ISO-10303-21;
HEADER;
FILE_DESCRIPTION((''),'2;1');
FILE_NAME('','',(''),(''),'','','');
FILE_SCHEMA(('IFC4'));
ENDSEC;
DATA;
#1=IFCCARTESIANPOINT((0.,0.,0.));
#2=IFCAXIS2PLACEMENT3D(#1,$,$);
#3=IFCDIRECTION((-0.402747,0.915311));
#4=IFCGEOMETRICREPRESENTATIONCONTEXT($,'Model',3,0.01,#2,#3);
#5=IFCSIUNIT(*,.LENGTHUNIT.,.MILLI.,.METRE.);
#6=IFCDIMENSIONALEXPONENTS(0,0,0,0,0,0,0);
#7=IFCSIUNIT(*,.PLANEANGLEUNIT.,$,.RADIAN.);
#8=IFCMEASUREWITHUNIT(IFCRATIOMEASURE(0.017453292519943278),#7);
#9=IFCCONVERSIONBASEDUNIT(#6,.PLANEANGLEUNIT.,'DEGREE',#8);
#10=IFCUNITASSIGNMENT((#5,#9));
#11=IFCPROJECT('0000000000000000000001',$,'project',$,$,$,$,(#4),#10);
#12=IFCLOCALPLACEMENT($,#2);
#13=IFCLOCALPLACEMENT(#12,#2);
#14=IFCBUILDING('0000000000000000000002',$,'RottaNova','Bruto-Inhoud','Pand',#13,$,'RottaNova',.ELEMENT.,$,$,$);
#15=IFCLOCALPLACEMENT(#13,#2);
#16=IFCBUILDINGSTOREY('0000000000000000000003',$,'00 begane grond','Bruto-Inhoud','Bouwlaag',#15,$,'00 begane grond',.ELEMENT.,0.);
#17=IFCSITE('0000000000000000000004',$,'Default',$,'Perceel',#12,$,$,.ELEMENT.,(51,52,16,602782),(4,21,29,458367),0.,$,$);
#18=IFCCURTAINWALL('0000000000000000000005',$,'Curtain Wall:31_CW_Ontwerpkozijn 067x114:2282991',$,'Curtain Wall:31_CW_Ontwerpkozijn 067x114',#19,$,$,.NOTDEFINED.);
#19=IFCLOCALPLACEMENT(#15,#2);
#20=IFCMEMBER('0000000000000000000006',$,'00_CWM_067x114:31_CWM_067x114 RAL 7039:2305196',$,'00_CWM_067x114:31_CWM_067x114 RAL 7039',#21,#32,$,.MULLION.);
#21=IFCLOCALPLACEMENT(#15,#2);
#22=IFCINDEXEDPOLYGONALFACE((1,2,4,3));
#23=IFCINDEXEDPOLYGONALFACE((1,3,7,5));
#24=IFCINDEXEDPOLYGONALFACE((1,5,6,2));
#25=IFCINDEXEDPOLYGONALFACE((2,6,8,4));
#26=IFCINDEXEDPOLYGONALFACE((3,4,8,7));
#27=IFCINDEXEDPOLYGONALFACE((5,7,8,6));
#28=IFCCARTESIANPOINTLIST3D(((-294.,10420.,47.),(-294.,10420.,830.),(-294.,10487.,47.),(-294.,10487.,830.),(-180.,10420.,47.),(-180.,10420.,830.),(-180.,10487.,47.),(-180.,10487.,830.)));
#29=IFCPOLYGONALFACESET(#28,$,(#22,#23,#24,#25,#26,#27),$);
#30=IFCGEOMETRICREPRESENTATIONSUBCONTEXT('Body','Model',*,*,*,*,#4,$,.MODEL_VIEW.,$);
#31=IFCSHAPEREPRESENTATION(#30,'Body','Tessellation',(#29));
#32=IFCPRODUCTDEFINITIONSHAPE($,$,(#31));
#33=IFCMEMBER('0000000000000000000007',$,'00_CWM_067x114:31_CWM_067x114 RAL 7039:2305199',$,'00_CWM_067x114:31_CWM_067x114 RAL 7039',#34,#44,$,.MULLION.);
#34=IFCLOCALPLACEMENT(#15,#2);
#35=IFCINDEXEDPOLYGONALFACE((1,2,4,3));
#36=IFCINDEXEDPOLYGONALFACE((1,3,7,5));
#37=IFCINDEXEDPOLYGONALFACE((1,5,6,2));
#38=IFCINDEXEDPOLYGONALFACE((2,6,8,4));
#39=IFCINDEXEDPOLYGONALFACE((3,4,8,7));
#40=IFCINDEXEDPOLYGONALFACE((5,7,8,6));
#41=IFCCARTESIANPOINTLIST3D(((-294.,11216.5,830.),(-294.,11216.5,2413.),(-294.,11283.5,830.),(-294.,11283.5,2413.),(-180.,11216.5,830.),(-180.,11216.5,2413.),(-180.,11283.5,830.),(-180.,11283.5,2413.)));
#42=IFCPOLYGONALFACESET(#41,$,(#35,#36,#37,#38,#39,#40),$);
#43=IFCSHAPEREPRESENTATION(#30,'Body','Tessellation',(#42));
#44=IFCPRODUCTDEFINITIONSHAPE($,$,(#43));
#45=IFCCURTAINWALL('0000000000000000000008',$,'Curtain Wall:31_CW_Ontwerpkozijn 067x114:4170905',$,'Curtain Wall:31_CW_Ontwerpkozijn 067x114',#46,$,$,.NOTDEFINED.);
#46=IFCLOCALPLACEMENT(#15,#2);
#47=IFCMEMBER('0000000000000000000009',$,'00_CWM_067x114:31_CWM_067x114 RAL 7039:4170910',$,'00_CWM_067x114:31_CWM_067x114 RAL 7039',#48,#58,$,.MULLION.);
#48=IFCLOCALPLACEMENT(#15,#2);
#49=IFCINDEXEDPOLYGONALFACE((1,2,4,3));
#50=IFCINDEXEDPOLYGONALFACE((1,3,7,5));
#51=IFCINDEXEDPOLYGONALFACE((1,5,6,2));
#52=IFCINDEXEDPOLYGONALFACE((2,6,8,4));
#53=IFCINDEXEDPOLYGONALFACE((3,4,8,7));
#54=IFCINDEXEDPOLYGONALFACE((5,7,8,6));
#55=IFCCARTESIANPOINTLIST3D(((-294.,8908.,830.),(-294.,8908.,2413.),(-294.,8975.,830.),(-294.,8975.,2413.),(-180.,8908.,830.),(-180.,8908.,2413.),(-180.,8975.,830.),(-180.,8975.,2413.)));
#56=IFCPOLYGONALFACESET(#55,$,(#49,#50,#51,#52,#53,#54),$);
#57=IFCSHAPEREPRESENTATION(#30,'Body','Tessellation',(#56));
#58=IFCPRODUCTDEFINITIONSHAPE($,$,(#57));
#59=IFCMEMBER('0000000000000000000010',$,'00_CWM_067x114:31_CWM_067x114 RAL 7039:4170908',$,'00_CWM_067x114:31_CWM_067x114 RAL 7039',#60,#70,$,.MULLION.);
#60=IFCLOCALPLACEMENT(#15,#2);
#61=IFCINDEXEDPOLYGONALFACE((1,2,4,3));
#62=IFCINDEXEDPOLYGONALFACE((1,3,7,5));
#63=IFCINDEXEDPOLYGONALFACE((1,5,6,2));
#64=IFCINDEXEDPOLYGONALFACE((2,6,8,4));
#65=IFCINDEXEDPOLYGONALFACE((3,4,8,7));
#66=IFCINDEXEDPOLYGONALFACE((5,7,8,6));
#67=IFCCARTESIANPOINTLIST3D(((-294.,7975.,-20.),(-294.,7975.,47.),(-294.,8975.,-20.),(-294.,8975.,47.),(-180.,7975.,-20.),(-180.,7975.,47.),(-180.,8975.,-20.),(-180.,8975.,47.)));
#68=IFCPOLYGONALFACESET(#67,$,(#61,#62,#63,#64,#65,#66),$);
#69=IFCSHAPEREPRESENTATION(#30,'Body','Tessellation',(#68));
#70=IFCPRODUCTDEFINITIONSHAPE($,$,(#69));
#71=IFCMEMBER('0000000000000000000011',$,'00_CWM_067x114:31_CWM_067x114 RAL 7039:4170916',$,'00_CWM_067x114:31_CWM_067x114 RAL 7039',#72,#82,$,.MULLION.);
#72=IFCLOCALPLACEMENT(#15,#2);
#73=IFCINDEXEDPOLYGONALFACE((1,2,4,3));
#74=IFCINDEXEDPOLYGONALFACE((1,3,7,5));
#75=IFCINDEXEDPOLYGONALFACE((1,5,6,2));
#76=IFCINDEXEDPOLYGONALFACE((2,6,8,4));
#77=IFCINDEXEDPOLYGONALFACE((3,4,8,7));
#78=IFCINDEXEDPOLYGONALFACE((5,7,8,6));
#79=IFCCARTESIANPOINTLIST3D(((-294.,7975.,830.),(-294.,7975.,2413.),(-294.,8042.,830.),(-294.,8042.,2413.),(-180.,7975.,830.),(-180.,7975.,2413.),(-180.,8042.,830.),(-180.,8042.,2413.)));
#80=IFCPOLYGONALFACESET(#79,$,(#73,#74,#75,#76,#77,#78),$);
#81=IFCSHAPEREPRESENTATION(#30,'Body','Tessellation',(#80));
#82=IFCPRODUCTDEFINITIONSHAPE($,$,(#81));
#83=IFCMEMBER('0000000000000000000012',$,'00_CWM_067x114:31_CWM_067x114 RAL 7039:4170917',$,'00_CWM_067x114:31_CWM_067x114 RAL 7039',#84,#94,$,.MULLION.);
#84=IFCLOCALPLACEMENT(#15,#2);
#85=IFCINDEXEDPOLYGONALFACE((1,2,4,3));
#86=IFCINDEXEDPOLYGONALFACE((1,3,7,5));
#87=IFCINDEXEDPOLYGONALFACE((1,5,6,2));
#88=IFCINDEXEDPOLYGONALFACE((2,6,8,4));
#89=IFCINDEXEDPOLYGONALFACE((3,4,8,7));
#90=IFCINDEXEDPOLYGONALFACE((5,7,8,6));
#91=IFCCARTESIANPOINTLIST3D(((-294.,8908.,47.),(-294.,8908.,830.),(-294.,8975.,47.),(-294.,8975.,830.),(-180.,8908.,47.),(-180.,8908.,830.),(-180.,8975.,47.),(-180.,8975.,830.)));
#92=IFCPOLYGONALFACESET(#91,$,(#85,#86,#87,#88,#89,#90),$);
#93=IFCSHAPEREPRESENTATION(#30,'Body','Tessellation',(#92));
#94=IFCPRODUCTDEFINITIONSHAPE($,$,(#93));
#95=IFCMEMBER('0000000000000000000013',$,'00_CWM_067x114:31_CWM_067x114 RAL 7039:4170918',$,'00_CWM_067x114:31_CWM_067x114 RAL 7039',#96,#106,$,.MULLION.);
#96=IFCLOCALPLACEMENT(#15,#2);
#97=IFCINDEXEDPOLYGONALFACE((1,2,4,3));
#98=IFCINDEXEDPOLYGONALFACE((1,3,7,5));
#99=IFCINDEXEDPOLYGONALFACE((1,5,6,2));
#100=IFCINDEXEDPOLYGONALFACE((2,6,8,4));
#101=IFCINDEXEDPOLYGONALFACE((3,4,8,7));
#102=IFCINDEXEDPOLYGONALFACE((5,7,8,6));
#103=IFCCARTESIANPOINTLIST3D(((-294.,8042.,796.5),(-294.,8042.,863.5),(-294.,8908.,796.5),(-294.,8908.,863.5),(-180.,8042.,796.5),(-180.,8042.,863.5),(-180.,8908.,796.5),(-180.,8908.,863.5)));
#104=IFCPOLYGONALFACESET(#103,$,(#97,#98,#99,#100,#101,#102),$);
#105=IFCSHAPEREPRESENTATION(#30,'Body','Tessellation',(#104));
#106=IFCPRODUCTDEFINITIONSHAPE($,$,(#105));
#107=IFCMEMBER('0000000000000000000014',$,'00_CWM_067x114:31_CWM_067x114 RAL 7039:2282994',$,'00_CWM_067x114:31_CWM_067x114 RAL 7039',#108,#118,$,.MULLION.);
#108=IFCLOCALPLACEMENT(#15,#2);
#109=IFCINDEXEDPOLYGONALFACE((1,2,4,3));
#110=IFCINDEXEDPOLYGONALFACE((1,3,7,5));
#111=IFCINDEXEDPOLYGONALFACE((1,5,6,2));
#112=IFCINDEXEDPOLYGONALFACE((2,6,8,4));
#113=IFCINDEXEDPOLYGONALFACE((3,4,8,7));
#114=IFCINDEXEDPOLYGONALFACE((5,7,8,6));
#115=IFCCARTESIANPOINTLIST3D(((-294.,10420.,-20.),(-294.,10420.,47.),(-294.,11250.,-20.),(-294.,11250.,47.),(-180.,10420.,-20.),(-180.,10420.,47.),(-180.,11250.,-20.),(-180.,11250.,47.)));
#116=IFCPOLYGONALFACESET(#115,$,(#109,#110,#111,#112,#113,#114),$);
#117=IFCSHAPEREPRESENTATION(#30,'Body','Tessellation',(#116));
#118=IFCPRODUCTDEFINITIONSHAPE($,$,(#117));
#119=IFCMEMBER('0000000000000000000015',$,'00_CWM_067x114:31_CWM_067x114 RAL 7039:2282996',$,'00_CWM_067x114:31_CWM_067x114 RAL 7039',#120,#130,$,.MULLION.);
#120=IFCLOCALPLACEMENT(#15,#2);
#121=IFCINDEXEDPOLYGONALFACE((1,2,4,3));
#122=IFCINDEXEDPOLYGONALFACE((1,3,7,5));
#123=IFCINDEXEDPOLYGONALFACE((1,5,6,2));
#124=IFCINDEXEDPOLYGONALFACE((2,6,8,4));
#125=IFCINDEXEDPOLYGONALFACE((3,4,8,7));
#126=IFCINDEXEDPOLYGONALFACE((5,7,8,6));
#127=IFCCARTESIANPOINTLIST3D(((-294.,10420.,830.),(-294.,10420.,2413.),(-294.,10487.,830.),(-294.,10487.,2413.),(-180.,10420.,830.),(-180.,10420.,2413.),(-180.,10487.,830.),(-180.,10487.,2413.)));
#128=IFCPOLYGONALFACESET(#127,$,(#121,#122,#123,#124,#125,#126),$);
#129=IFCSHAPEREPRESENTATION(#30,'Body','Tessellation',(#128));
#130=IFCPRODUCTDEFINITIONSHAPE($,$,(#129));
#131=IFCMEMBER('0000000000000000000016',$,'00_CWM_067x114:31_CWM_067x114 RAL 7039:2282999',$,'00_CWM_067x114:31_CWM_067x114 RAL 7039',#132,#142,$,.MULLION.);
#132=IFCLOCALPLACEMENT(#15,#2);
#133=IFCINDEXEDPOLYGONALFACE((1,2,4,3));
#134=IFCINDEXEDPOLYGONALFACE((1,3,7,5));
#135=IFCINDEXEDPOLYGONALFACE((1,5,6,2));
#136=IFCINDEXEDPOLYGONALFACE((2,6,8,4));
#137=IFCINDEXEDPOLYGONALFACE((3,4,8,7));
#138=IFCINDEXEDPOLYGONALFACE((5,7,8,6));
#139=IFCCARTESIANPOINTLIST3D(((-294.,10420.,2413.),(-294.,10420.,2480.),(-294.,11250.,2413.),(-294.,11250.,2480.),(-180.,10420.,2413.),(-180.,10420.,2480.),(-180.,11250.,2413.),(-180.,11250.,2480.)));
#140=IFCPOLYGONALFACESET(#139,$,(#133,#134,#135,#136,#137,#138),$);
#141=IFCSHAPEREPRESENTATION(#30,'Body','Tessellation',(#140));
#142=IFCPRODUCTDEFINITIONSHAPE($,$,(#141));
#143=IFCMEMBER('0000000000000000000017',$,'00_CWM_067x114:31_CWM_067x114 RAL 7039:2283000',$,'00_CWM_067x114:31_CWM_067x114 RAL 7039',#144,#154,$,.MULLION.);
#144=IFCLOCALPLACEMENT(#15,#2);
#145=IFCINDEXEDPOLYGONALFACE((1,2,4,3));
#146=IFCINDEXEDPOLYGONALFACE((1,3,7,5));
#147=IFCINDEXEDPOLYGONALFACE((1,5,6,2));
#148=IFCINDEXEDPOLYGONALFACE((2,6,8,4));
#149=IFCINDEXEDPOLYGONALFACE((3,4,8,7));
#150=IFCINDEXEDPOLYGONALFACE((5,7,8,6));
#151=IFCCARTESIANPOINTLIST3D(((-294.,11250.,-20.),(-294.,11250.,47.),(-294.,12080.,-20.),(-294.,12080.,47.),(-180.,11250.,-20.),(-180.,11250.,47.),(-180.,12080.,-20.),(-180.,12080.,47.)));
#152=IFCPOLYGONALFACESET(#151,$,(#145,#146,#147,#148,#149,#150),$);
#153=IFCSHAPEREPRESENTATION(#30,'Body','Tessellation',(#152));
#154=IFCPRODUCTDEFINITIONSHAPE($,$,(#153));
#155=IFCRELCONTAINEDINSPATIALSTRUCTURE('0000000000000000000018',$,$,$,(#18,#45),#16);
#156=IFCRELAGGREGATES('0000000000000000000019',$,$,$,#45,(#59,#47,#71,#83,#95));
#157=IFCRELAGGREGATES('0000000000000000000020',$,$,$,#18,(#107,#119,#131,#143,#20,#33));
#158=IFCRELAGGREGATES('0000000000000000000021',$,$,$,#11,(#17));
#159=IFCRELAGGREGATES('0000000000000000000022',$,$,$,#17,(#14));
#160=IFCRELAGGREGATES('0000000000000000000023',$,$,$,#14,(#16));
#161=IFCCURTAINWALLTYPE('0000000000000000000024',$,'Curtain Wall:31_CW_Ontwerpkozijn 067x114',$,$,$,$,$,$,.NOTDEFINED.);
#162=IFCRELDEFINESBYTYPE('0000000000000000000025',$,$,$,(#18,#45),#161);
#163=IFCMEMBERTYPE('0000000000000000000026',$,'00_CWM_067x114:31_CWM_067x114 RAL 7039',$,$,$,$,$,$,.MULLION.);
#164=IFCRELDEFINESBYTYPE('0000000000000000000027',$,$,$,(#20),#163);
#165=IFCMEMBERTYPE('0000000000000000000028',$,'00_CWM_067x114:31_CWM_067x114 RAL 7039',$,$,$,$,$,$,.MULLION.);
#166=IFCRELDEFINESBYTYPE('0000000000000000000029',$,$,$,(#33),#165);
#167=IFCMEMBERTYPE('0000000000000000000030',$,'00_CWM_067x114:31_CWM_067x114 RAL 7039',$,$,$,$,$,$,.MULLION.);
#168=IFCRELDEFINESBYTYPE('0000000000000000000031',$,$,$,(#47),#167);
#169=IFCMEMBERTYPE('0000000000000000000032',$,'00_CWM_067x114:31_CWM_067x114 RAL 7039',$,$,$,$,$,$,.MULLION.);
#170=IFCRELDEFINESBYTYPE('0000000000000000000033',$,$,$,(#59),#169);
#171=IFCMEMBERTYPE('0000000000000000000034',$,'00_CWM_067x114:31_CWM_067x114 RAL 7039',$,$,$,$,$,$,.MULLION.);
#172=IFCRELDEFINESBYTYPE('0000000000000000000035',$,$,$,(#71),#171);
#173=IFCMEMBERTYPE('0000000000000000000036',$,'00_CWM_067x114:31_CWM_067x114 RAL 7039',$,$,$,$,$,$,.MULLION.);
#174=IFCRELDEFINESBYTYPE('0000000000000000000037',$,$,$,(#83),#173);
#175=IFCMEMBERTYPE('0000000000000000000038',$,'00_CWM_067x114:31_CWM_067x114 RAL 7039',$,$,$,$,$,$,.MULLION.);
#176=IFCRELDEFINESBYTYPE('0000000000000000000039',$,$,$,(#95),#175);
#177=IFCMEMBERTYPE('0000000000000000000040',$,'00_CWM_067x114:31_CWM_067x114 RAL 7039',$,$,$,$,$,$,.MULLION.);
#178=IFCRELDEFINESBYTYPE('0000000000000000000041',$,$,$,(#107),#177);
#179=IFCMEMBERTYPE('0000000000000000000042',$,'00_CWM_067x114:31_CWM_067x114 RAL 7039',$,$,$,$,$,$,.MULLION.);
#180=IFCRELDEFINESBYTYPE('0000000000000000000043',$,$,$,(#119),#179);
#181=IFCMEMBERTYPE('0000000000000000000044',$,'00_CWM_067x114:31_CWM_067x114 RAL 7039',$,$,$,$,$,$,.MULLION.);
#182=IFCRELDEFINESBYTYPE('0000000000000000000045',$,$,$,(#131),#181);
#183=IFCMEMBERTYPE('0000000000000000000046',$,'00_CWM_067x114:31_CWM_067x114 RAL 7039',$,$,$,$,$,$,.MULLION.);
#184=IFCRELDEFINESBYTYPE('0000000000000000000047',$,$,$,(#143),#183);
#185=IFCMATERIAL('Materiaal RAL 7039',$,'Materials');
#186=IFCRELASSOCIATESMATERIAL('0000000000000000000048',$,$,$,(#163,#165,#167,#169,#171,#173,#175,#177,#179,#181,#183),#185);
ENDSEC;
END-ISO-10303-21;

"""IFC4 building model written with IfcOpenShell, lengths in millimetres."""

from ifc_helpers import new_model, entity, si_unit, converted_unit, direction, frame, frame_2d, origin, origin_2d_with_axis, place, context, subcontext, project, spatial, rectangle, extrude, source, transform, mapped, material, material_profile, profile_set, type_object, type_shapes, element, aggregate, save


model = new_model("IFC4")

# Units and contexts
model_context = context("Model", 3, precision=0.01, world=origin(), true_north=direction((-0.402747, 0.915311)))
body_context = subcontext(model_context, "Body", "Model", "MODEL_VIEW")
ifc_project = project(units=[si_unit("LENGTHUNIT", "METRE", prefix="MILLI"), converted_unit("PLANEANGLEUNIT", "DEGREE", entity("IfcRatioMeasure", 0.017453292519943278), si_unit("PLANEANGLEUNIT", "RADIAN"), dimensions=[0, 0, 0, 0, 0, 0, 0])], contexts=[model_context])

# Site, building, storey
site_placement = place(None, origin())
site = spatial("IfcSite", under=ifc_project, at=site_placement, Name="Default", ObjectType="Perceel", CompositionType="ELEMENT", RefLatitude=(51, 52, 16, 602782), RefLongitude=(4, 21, 29, 458367), RefElevation=0.0)
building_placement = place(site_placement, origin())
building = spatial("IfcBuilding", under=site, at=building_placement, Name="RottaNova", Description="Bruto-Inhoud", ObjectType="Pand", LongName="RottaNova", CompositionType="ELEMENT")
storey_placement = place(building_placement, origin())
storey = spatial("IfcBuildingStorey", under=building, at=storey_placement, Name="00 begane grond", Description="Bruto-Inhoud", ObjectType="Bouwlaag", LongName="00 begane grond", CompositionType="ELEMENT", Elevation=0.0)

# Curtain walls, members
curtain_wall_type = type_object("IfcCurtainWallType", Name="Curtain Wall:31_CW_Ontwerpkozijn 067x114", PredefinedType="NOTDEFINED")
curtain_wall_1_placement = place(storey_placement, origin())
curtain_wall_1 = element("IfcCurtainWall", 1, at=curtain_wall_1_placement, inside=storey, type_object=curtain_wall_type, Name="Curtain Wall:31_CW_Ontwerpkozijn 067x114:2282991", ObjectType="Curtain Wall:31_CW_Ontwerpkozijn 067x114", PredefinedType="NOTDEFINED")
ifc_material_1 = material(Name="Materiaal RAL 7039", Category="Materials")
ifc_material_profile = material_profile(ifc_material_1, rectangle(XDim=114.0, YDim=67.0, at=origin_2d_with_axis()), Name="31_CWM_067x114 RAL 7039")
ifc_profile_set = profile_set([ifc_material_profile], Name="31_CWM_067x114 RAL 7039")
member_type_1 = type_object("IfcMemberType", Name="00_CWM_067x114:31_CWM_067x114 RAL 7039", PredefinedType="MULLION", material=ifc_profile_set)
shared_shape_1 = source(origin(), body_context, "Body", "SweptSolid", [
    extrude(rectangle(XDim=114.0, YDim=67.0, at=frame_2d((0.0, 0.0), x_axis=(1.0, 0.0))), frame((-33.5, -57.0, -783.0), z_axis=(0.0, 0.0, 1.0), x_axis=(0.0, -1.0, 0.0)), (0.0, 0.0, 1.0), 783.0),
])
type_shapes(member_type_1, [shared_shape_1])
member_1_placement = place(curtain_wall_1_placement, frame((-180.0, 10420.0, 830.0), z_axis=(0.0, 0.0, 1.0), x_axis=(0.0, -1.0, 0.0)))
member_1 = element("IfcMember", 2, at=member_1_placement, type_object=member_type_1, Name="00_CWM_067x114:31_CWM_067x114 RAL 7039:2305196", ObjectType="00_CWM_067x114:31_CWM_067x114 RAL 7039", PredefinedType="MULLION", context=body_context, shape_type="MappedRepresentation", body=[
    mapped(shared_shape_1, transform((0.0, 0.0, 0.0), scale=1.0)),
])
member_type_2 = type_object("IfcMemberType", Name="00_CWM_067x114:31_CWM_067x114 RAL 7039", PredefinedType="MULLION", material=ifc_profile_set)
shared_shape_2 = source(origin(), body_context, "Body", "SweptSolid", [
    extrude(rectangle(XDim=114.0, YDim=67.0, at=origin_2d_with_axis()), frame((0.0, -57.0, -1583.0), z_axis=(0.0, 0.0, 1.0), x_axis=(0.0, -1.0, 0.0)), (0.0, 0.0, 1.0), 1583.0),
])
type_shapes(member_type_2, [shared_shape_2])
member_2_placement = place(curtain_wall_1_placement, frame((-180.0, 11250.0, 830.0), z_axis=(0.0, 0.0, -1.0), x_axis=(0.0, 1.0, 0.0)))
member_2 = element("IfcMember", 3, at=member_2_placement, type_object=member_type_2, Name="00_CWM_067x114:31_CWM_067x114 RAL 7039:2305199", ObjectType="00_CWM_067x114:31_CWM_067x114 RAL 7039", PredefinedType="MULLION", context=body_context, shape_type="MappedRepresentation", body=[
    mapped(shared_shape_2, transform((0.0, 0.0, 0.0), scale=1.0)),
])
curtain_wall_2_placement = place(storey_placement, origin())
curtain_wall_2 = element("IfcCurtainWall", 4, at=curtain_wall_2_placement, inside=storey, type_object=curtain_wall_type, Name="Curtain Wall:31_CW_Ontwerpkozijn 067x114:4170905", ObjectType="Curtain Wall:31_CW_Ontwerpkozijn 067x114", PredefinedType="NOTDEFINED")
member_type_3 = type_object("IfcMemberType", Name="00_CWM_067x114:31_CWM_067x114 RAL 7039", PredefinedType="MULLION", material=ifc_profile_set)
shared_shape_3 = source(origin(), body_context, "Body", "SweptSolid", [
    extrude(rectangle(XDim=114.0, YDim=67.0, at=origin_2d_with_axis()), frame((-33.5, 57.0, -1583.0), z_axis=(0.0, 0.0, 1.0), x_axis=(0.0, -1.0, 0.0)), (0.0, 0.0, 1.0), 1583.0),
])
type_shapes(member_type_3, [shared_shape_3])
member_3_placement = place(curtain_wall_2_placement, frame((-180.0, 8975.0, 2413.0), z_axis=(0.0, 0.0, 1.0), x_axis=(0.0, 1.0, 0.0)))
member_3 = element("IfcMember", 5, at=member_3_placement, type_object=member_type_3, Name="00_CWM_067x114:31_CWM_067x114 RAL 7039:4170910", ObjectType="00_CWM_067x114:31_CWM_067x114 RAL 7039", PredefinedType="MULLION", context=body_context, shape_type="MappedRepresentation", body=[
    mapped(shared_shape_3, transform((0.0, 0.0, 0.0), scale=1.0)),
])
member_type_4 = type_object("IfcMemberType", Name="00_CWM_067x114:31_CWM_067x114 RAL 7039", PredefinedType="MULLION", material=ifc_profile_set)
shared_shape_4 = source(origin(), body_context, "Body", "SweptSolid", [
    extrude(rectangle(XDim=114.0, YDim=67.0, at=origin_2d_with_axis()), frame((-33.5, 57.0, -1000.0), z_axis=(0.0, 0.0, 1.0), x_axis=(0.0, -1.0, 0.0)), (0.0, 0.0, 1.0), 1000.0),
])
type_shapes(member_type_4, [shared_shape_4])
member_4_placement = place(curtain_wall_2_placement, frame((-180.0, 8975.0, -20.0), z_axis=(0.0, 1.0, 0.0), x_axis=(0.0, 0.0, -1.0)))
member_4 = element("IfcMember", 6, at=member_4_placement, type_object=member_type_4, Name="00_CWM_067x114:31_CWM_067x114 RAL 7039:4170908", ObjectType="00_CWM_067x114:31_CWM_067x114 RAL 7039", PredefinedType="MULLION", context=body_context, shape_type="MappedRepresentation", body=[
    mapped(shared_shape_4, transform((0.0, 0.0, 0.0), scale=1.0)),
])
member_type_5 = type_object("IfcMemberType", Name="00_CWM_067x114:31_CWM_067x114 RAL 7039", PredefinedType="MULLION", material=ifc_profile_set)
shared_shape_5 = source(origin(), body_context, "Body", "SweptSolid", [
    extrude(rectangle(XDim=114.0, YDim=67.0, at=origin_2d_with_axis()), frame((-33.5, 57.0, -1583.0), z_axis=(0.0, 0.0, 1.0), x_axis=(0.0, -1.0, 0.0)), (0.0, 0.0, 1.0), 1583.0),
])
type_shapes(member_type_5, [shared_shape_5])
member_5_placement = place(curtain_wall_2_placement, frame((-180.0, 7975.0, 830.0), z_axis=(0.0, 0.0, -1.0), x_axis=(0.0, -1.0, 0.0)))
member_5 = element("IfcMember", 7, at=member_5_placement, type_object=member_type_5, Name="00_CWM_067x114:31_CWM_067x114 RAL 7039:4170916", ObjectType="00_CWM_067x114:31_CWM_067x114 RAL 7039", PredefinedType="MULLION", context=body_context, shape_type="MappedRepresentation", body=[
    mapped(shared_shape_5, transform((0.0, 0.0, 0.0), scale=1.0)),
])
member_type_6 = type_object("IfcMemberType", Name="00_CWM_067x114:31_CWM_067x114 RAL 7039", PredefinedType="MULLION", material=ifc_profile_set)
shared_shape_6 = source(origin(), body_context, "Body", "SweptSolid", [
    extrude(rectangle(XDim=114.0, YDim=67.0, at=origin_2d_with_axis()), frame((-33.5, 57.0, -783.0), z_axis=(0.0, 0.0, 1.0), x_axis=(0.0, -1.0, 0.0)), (0.0, 0.0, 1.0), 783.0),
])
type_shapes(member_type_6, [shared_shape_6])
member_6_placement = place(curtain_wall_2_placement, frame((-180.0, 8975.0, 830.0), z_axis=(0.0, 0.0, 1.0), x_axis=(0.0, 1.0, 0.0)))
member_6 = element("IfcMember", 8, at=member_6_placement, type_object=member_type_6, Name="00_CWM_067x114:31_CWM_067x114 RAL 7039:4170917", ObjectType="00_CWM_067x114:31_CWM_067x114 RAL 7039", PredefinedType="MULLION", context=body_context, shape_type="MappedRepresentation", body=[
    mapped(shared_shape_6, transform((0.0, 0.0, 0.0), scale=1.0)),
])
member_type_7 = type_object("IfcMemberType", Name="00_CWM_067x114:31_CWM_067x114 RAL 7039", PredefinedType="MULLION", material=ifc_profile_set)
shared_shape_7 = source(origin(), body_context, "Body", "SweptSolid", [
    extrude(rectangle(XDim=114.0, YDim=67.0, at=origin_2d_with_axis()), frame((0.0, 57.0, -866.0), z_axis=(0.0, 0.0, 1.0), x_axis=(0.0, -1.0, 0.0)), (0.0, 0.0, 1.0), 866.0),
])
type_shapes(member_type_7, [shared_shape_7])
member_7_placement = place(curtain_wall_2_placement, frame((-180.0, 8042.0, 830.0), z_axis=(0.0, -1.0, 0.0), x_axis=(0.0, 0.0, 1.0)))
member_7 = element("IfcMember", 9, at=member_7_placement, type_object=member_type_7, Name="00_CWM_067x114:31_CWM_067x114 RAL 7039:4170918", ObjectType="00_CWM_067x114:31_CWM_067x114 RAL 7039", PredefinedType="MULLION", context=body_context, shape_type="MappedRepresentation", body=[
    mapped(shared_shape_7, transform((0.0, 0.0, 0.0), scale=1.0)),
])

# Members
member_type_8 = type_object("IfcMemberType", Name="00_CWM_067x114:31_CWM_067x114 RAL 7039", PredefinedType="MULLION", material=ifc_profile_set)
shared_shape_8 = source(origin(), body_context, "Body", "SweptSolid", [
    extrude(rectangle(XDim=114.0, YDim=67.0, at=frame_2d((0.0, 0.0), x_axis=(1.0, 0.0))), frame((-33.5, -57.0, -830.0), z_axis=(0.0, 0.0, 1.0), x_axis=(0.0, -1.0, 0.0)), (0.0, 0.0, 1.0), 830.0),
])
type_shapes(member_type_8, [shared_shape_8])
member_8_placement = place(curtain_wall_1_placement, frame((-180.0, 10420.0, -20.0), z_axis=(0.0, -1.0, 0.0), x_axis=(0.0, 0.0, -1.0)))
member_8 = element("IfcMember", 10, at=member_8_placement, type_object=member_type_8, Name="00_CWM_067x114:31_CWM_067x114 RAL 7039:2282994", ObjectType="00_CWM_067x114:31_CWM_067x114 RAL 7039", PredefinedType="MULLION", context=body_context, shape_type="MappedRepresentation", body=[
    mapped(shared_shape_8, transform((0.0, 0.0, 0.0), scale=1.0)),
])
member_type_9 = type_object("IfcMemberType", Name="00_CWM_067x114:31_CWM_067x114 RAL 7039", PredefinedType="MULLION", material=ifc_profile_set)
shared_shape_9 = source(origin(), body_context, "Body", "SweptSolid", [
    extrude(rectangle(XDim=114.0, YDim=67.0, at=origin_2d_with_axis()), frame((-33.5, -57.0, -1583.0), z_axis=(0.0, 0.0, 1.0), x_axis=(0.0, -1.0, 0.0)), (0.0, 0.0, 1.0), 1583.0),
])
type_shapes(member_type_9, [shared_shape_9])
member_9_placement = place(curtain_wall_1_placement, frame((-180.0, 10420.0, 2413.0), z_axis=(0.0, 0.0, 1.0), x_axis=(0.0, -1.0, 0.0)))
member_9 = element("IfcMember", 11, at=member_9_placement, type_object=member_type_9, Name="00_CWM_067x114:31_CWM_067x114 RAL 7039:2282996", ObjectType="00_CWM_067x114:31_CWM_067x114 RAL 7039", PredefinedType="MULLION", context=body_context, shape_type="MappedRepresentation", body=[
    mapped(shared_shape_9, transform((0.0, 0.0, 0.0), scale=1.0)),
])
member_type_10 = type_object("IfcMemberType", Name="00_CWM_067x114:31_CWM_067x114 RAL 7039", PredefinedType="MULLION", material=ifc_profile_set)
shared_shape_10 = source(origin(), body_context, "Body", "SweptSolid", [
    extrude(rectangle(XDim=114.0, YDim=67.0, at=frame_2d((0.0, 0.0), x_axis=(1.0, 0.0))), frame((-33.5, -57.0, -830.0), z_axis=(0.0, 0.0, 1.0), x_axis=(0.0, -1.0, 0.0)), (0.0, 0.0, 1.0), 830.0),
])
type_shapes(member_type_10, [shared_shape_10])
member_10_placement = place(curtain_wall_1_placement, frame((-180.0, 11250.0, 2480.0), z_axis=(0.0, 1.0, 0.0), x_axis=(0.0, 0.0, 1.0)))
member_10 = element("IfcMember", 12, at=member_10_placement, type_object=member_type_10, Name="00_CWM_067x114:31_CWM_067x114 RAL 7039:2282999", ObjectType="00_CWM_067x114:31_CWM_067x114 RAL 7039", PredefinedType="MULLION", context=body_context, shape_type="MappedRepresentation", body=[
    mapped(shared_shape_10, transform((0.0, 0.0, 0.0), scale=1.0)),
])
member_type_11 = type_object("IfcMemberType", Name="00_CWM_067x114:31_CWM_067x114 RAL 7039", PredefinedType="MULLION", material=ifc_profile_set)
shared_shape_11 = source(origin(), body_context, "Body", "SweptSolid", [
    extrude(rectangle(XDim=114.0, YDim=67.0, at=frame_2d((0.0, 0.0), x_axis=(1.0, 0.0))), frame((-33.5, -57.0, -830.0), z_axis=(0.0, 0.0, 1.0), x_axis=(0.0, -1.0, 0.0)), (0.0, 0.0, 1.0), 830.0),
])
type_shapes(member_type_11, [shared_shape_11])
member_11_placement = place(curtain_wall_1_placement, frame((-180.0, 11250.0, -20.0), z_axis=(0.0, -1.0, 0.0), x_axis=(0.0, 0.0, -1.0)))
member_11 = element("IfcMember", 13, at=member_11_placement, type_object=member_type_11, Name="00_CWM_067x114:31_CWM_067x114 RAL 7039:2283000", ObjectType="00_CWM_067x114:31_CWM_067x114 RAL 7039", PredefinedType="MULLION", context=body_context, shape_type="MappedRepresentation", body=[
    mapped(shared_shape_11, transform((0.0, 0.0, 0.0), scale=1.0)),
])

aggregate(curtain_wall_2, [member_4, member_3, member_5, member_6, member_7])
aggregate(curtain_wall_1, [member_8, member_9, member_10, member_11, member_1, member_2])

save(model, "model.ifc")
